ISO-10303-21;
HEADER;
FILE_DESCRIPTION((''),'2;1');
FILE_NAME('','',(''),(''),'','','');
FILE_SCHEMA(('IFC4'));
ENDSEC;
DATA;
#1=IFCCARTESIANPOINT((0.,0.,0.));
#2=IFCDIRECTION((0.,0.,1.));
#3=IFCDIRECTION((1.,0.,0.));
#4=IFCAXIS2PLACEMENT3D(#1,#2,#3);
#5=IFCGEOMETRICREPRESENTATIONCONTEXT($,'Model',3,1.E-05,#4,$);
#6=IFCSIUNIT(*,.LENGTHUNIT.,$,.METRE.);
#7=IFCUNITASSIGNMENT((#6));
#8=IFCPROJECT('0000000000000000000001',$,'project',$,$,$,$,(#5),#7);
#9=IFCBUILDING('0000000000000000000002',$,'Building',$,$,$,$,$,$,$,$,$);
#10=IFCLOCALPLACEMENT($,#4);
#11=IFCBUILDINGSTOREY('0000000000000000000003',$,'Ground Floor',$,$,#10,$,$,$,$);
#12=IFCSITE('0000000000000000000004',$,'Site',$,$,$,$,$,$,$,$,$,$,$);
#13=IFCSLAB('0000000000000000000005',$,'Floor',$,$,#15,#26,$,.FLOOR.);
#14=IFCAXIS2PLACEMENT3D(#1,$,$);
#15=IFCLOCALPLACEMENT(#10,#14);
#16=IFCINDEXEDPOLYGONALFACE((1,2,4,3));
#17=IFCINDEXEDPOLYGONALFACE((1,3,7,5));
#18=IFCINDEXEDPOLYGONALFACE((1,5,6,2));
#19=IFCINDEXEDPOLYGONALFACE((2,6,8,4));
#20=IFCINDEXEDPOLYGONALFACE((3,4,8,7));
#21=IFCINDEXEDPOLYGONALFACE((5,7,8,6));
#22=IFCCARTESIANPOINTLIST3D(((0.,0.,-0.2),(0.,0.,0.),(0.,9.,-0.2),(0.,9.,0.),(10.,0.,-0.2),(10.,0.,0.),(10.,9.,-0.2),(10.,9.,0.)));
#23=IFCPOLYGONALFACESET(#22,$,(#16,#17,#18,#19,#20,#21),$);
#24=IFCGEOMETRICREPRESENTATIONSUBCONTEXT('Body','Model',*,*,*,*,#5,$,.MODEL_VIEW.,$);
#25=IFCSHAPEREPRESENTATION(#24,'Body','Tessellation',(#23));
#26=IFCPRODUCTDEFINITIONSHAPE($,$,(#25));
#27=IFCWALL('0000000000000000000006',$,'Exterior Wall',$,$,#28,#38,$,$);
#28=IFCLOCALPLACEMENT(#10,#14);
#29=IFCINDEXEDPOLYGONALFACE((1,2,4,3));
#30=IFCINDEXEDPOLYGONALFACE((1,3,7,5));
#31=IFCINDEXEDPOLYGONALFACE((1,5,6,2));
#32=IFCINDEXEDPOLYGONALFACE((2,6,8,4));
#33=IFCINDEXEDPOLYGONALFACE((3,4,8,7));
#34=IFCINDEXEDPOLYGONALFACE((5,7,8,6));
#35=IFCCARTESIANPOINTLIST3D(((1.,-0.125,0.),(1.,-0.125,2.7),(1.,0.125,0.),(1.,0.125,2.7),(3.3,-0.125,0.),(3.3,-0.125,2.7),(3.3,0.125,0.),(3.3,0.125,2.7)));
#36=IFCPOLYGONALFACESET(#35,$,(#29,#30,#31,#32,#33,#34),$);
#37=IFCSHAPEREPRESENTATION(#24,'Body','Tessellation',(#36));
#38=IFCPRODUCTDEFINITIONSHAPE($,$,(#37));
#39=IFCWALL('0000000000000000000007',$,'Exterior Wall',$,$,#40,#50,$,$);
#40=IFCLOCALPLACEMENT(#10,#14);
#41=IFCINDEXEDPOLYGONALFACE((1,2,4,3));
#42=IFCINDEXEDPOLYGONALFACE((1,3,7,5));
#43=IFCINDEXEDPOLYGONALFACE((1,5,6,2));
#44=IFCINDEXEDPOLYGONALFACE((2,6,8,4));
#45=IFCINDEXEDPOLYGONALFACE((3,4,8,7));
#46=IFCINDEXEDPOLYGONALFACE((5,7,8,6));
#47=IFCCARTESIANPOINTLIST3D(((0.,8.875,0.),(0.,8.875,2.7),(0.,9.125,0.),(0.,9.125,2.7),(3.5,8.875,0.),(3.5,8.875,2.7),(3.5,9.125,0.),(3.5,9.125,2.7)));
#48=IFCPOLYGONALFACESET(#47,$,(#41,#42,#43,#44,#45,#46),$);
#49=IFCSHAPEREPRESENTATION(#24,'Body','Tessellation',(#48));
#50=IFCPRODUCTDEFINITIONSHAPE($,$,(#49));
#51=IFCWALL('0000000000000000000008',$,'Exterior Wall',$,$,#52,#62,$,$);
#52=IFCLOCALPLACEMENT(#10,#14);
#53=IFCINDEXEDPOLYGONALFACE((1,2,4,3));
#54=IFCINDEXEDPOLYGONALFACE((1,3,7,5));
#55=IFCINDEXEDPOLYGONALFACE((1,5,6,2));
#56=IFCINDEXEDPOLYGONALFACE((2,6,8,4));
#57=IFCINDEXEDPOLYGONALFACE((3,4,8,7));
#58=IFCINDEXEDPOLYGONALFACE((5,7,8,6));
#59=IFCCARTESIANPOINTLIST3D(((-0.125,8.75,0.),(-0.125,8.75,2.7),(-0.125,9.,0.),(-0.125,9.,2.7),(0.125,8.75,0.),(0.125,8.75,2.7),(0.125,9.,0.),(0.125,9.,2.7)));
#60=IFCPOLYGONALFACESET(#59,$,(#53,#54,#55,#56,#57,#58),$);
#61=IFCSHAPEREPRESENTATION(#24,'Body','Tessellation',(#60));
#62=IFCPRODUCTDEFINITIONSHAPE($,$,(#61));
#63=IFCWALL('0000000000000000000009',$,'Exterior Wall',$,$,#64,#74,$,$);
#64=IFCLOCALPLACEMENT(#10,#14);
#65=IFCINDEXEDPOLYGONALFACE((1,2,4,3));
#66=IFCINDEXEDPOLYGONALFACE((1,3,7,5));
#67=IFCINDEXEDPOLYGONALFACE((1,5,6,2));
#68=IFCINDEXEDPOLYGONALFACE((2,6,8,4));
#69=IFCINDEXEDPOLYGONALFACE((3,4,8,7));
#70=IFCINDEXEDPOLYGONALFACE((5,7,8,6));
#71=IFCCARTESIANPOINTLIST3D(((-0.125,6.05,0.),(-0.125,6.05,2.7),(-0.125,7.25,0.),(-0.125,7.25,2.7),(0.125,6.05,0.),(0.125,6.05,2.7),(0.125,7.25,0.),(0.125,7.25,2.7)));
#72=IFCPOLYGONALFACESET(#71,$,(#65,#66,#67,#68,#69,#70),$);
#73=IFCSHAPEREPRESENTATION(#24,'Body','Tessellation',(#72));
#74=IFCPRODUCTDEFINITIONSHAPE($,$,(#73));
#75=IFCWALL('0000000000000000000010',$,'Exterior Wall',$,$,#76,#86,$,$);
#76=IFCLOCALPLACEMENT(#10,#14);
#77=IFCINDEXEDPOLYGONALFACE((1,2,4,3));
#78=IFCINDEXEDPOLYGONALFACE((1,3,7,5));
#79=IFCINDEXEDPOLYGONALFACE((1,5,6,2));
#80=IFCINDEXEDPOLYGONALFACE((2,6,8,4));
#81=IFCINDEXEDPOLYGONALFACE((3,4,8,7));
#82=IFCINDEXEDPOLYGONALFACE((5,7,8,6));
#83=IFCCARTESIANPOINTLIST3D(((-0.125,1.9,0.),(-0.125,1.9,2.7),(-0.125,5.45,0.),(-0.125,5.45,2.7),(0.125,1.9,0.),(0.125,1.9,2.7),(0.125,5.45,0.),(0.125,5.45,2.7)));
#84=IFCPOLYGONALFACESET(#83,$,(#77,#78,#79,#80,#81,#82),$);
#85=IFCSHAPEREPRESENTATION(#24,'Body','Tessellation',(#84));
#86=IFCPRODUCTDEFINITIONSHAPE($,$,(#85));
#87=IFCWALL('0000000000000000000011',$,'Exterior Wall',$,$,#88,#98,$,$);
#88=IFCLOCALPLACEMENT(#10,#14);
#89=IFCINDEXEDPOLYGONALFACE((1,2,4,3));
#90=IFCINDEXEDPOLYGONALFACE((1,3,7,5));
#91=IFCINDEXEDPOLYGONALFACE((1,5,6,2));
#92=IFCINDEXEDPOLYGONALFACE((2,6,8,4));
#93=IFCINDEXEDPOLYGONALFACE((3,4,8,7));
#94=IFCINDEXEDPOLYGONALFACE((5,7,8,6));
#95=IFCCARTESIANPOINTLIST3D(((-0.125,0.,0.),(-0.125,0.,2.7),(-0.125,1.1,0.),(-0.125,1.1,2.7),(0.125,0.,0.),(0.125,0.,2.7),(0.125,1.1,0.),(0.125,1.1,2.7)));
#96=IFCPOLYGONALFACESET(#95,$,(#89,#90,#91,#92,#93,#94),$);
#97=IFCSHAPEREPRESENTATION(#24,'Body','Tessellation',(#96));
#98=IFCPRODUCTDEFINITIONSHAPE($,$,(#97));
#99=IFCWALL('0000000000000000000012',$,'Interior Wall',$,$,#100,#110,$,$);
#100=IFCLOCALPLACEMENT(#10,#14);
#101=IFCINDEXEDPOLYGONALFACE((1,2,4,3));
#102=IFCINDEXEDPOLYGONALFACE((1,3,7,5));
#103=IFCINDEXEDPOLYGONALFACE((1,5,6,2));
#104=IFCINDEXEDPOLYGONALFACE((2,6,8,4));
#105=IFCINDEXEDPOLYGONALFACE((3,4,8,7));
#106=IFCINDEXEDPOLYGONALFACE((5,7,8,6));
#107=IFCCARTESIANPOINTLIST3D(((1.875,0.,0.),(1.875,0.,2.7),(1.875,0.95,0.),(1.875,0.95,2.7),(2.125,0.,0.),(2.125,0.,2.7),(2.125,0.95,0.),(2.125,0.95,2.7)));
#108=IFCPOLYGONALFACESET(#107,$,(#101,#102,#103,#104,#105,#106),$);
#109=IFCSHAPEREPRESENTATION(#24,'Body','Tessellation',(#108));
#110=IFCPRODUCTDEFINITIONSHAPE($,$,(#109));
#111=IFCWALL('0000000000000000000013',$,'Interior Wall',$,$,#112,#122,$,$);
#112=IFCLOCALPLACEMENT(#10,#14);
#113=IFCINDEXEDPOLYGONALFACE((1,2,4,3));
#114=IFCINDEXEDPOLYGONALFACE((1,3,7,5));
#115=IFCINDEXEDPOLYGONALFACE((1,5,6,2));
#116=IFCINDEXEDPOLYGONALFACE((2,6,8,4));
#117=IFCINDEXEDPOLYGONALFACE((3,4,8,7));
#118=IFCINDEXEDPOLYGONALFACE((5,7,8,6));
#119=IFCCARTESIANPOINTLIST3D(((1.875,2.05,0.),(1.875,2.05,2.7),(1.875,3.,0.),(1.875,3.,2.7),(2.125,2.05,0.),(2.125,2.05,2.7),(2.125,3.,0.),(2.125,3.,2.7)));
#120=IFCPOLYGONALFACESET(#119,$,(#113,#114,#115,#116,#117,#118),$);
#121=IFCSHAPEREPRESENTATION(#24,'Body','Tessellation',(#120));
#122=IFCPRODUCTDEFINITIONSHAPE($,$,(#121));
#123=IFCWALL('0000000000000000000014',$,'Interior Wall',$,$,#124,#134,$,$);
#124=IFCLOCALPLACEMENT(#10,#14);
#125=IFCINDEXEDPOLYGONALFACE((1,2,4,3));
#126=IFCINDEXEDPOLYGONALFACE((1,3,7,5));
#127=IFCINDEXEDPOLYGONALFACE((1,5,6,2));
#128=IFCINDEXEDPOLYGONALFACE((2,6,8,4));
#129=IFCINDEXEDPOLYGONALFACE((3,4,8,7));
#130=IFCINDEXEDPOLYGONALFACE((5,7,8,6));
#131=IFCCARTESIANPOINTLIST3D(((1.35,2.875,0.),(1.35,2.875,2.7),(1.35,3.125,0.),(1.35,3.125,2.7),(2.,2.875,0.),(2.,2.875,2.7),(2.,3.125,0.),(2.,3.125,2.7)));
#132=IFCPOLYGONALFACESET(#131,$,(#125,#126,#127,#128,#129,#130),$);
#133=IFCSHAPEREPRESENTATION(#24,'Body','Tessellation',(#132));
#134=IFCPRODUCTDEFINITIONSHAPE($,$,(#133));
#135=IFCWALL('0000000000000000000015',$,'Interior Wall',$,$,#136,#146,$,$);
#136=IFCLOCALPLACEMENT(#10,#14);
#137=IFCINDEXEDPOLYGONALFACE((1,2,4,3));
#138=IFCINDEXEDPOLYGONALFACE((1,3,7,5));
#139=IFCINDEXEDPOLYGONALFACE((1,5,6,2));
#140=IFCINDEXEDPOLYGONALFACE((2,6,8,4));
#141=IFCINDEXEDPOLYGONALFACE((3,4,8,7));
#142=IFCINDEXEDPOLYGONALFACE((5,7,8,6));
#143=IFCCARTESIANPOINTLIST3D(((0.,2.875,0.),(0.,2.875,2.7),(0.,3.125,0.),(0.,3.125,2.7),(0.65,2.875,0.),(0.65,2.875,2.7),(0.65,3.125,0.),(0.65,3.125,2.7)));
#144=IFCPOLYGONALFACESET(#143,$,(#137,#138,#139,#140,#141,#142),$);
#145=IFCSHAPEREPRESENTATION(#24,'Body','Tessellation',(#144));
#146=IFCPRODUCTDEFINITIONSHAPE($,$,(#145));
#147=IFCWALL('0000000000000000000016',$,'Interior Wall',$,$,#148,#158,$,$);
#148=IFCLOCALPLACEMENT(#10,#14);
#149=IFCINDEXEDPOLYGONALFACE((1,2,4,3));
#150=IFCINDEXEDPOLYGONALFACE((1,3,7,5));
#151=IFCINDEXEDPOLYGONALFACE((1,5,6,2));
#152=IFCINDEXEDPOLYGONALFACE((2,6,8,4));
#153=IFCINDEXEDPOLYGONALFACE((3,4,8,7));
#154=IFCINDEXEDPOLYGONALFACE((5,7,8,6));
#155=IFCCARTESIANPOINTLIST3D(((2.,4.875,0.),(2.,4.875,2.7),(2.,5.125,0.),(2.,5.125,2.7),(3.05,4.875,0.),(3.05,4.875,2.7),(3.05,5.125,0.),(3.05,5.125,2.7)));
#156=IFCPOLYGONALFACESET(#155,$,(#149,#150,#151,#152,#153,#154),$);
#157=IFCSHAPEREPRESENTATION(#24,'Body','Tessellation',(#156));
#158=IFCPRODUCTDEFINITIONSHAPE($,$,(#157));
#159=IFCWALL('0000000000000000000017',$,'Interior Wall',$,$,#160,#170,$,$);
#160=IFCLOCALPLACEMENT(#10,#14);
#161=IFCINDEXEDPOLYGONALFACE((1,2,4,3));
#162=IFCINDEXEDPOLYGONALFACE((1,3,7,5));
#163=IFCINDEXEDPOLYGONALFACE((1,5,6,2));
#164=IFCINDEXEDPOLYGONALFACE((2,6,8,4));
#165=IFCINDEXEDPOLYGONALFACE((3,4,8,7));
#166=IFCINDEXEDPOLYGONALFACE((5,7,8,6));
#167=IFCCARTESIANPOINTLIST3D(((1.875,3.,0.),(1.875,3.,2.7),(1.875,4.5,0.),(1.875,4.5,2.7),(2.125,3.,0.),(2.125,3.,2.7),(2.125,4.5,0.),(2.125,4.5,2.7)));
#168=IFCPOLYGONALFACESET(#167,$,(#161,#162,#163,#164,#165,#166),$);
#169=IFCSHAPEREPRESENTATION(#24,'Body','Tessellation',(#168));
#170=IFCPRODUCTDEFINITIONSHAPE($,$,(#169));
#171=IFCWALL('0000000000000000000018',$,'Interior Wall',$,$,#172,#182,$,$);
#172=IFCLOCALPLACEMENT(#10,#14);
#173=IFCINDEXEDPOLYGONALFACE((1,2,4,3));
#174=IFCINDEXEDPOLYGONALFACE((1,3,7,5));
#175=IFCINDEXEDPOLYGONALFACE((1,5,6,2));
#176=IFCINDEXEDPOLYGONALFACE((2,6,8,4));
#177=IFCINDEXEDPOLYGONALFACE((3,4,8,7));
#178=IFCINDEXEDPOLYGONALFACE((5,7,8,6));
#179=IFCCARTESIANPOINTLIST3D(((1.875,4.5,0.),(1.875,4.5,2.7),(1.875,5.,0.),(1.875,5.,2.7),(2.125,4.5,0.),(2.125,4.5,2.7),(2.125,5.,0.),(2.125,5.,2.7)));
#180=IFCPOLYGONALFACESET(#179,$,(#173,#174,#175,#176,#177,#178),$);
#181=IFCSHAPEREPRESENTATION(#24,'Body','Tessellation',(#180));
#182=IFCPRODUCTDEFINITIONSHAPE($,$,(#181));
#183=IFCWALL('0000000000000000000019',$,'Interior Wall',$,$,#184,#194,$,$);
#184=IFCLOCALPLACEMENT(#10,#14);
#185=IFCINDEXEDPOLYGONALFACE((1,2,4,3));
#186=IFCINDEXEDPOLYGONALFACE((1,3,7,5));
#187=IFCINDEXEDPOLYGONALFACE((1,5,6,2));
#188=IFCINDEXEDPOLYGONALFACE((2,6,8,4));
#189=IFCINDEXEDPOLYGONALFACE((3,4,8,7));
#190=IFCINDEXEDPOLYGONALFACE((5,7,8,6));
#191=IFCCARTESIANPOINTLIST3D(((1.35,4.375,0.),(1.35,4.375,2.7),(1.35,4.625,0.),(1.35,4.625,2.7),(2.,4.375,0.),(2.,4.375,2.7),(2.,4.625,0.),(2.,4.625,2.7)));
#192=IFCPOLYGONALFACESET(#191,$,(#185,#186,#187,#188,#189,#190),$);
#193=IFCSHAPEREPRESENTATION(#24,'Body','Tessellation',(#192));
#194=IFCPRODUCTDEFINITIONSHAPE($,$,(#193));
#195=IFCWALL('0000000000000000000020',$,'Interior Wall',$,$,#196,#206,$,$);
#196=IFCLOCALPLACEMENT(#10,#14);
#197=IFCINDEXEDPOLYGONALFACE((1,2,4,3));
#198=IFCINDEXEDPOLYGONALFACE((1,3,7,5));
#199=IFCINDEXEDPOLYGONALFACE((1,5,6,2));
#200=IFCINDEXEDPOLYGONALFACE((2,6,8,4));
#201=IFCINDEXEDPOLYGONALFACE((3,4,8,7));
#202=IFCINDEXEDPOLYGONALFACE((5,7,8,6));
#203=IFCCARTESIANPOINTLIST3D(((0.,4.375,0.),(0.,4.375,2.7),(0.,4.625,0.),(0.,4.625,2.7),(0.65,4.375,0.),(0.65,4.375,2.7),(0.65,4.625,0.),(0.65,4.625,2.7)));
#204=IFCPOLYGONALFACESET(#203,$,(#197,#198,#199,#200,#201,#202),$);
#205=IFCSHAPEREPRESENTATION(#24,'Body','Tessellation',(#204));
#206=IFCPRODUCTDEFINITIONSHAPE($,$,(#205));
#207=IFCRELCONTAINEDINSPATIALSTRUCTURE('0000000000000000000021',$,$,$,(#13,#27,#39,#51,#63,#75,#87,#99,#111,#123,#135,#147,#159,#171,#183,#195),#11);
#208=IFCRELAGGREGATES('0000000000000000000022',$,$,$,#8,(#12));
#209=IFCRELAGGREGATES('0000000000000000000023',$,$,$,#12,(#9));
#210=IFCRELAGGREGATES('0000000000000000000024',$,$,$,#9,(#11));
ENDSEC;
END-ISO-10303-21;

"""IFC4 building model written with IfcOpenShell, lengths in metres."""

from ifc_helpers import new_model, si_unit, frame, origin_with_axes, place, context, subcontext, project, spatial, indexed_curve, outline, extrude, element, save


model = new_model("IFC4")

# Units and contexts
model_context = context("Model", 3, precision=1e-05, world=origin_with_axes())
body_context = subcontext(model_context, "Body", "Model", "MODEL_VIEW")
ifc_project = project(units=[si_unit("LENGTHUNIT", "METRE")], contexts=[model_context])

# Site, building, storey
site = spatial("IfcSite", under=ifc_project, Name="Site")
building = spatial("IfcBuilding", under=site, Name="Building")
storey_placement = place(None, origin_with_axes())
storey = spatial("IfcBuildingStorey", under=building, at=storey_placement, Name="Ground Floor")

# Slab
slab_placement = place(storey_placement, frame((0.0, 0.0, -0.2), z_axis=(0.0, 0.0, 1.0), x_axis=(1.0, 0.0, 0.0)))
element("IfcSlab", 1, at=slab_placement, inside=storey, Name="Floor", PredefinedType="FLOOR", context=body_context, shape_type="SweptSolid", body=[
    extrude(outline(indexed_curve([(0.0, 0.0), (10.0, 0.0), (10.0, 9.0), (0.0, 9.0)])), None, (0.0, 0.0, 1.0), 0.2),
])

# Walls
wall_1_placement = place(storey_placement, frame((1.0, 0.0, 0.0), z_axis=(0.0, 0.0, 1.0), x_axis=(1.0, 0.0, 0.0)))
element("IfcWall", 2, at=wall_1_placement, inside=storey, Name="Exterior Wall", context=body_context, shape_type="SweptSolid", body=[
    extrude(outline(indexed_curve([(0.0, 0.0), (0.0, 0.25), (2.3, 0.25), (2.3, 0.0), (0.0, 0.0)], self_intersect=False)), frame((0.0, -0.125, 0.0), z_axis=(0.0, 0.0, 1.0), x_axis=(1.0, 0.0, 0.0)), (0.0, 0.0, 1.0), 2.7),
])
wall_2_placement = place(storey_placement, frame((3.5, 9.0, 0.0), z_axis=(0.0, 0.0, 1.0), x_axis=(-1.0, 0.0, 0.0)))
element("IfcWall", 3, at=wall_2_placement, inside=storey, Name="Exterior Wall", context=body_context, shape_type="SweptSolid", body=[
    extrude(outline(indexed_curve([(0.0, 0.0), (0.0, 0.25), (3.5, 0.25), (3.5, 0.0), (0.0, 0.0)], self_intersect=False)), frame((0.0, -0.125, 0.0), z_axis=(0.0, 0.0, 1.0), x_axis=(1.0, 0.0, 0.0)), (0.0, 0.0, 1.0), 2.7),
])
wall_3_placement = place(storey_placement, frame((0.0, 9.0, 0.0), z_axis=(0.0, 0.0, 1.0), x_axis=(0.0, -1.0, 0.0)))
element("IfcWall", 4, at=wall_3_placement, inside=storey, Name="Exterior Wall", context=body_context, shape_type="SweptSolid", body=[
    extrude(outline(indexed_curve([(0.0, 0.0), (0.0, 0.25), (0.25, 0.25), (0.25, 0.0), (0.0, 0.0)], self_intersect=False)), frame((0.0, -0.125, 0.0), z_axis=(0.0, 0.0, 1.0), x_axis=(1.0, 0.0, 0.0)), (0.0, 0.0, 1.0), 2.7),
])
wall_4_placement = place(storey_placement, frame((0.0, 7.25, 0.0), z_axis=(0.0, 0.0, 1.0), x_axis=(0.0, -1.0, 0.0)))
element("IfcWall", 5, at=wall_4_placement, inside=storey, Name="Exterior Wall", context=body_context, shape_type="SweptSolid", body=[
    extrude(outline(indexed_curve([(0.0, 0.0), (0.0, 0.25), (1.2, 0.25), (1.2, 0.0), (0.0, 0.0)], self_intersect=False)), frame((0.0, -0.125, 0.0), z_axis=(0.0, 0.0, 1.0), x_axis=(1.0, 0.0, 0.0)), (0.0, 0.0, 1.0), 2.7),
])
wall_5_placement = place(storey_placement, frame((0.0, 5.45, 0.0), z_axis=(0.0, 0.0, 1.0), x_axis=(0.0, -1.0, 0.0)))
element("IfcWall", 6, at=wall_5_placement, inside=storey, Name="Exterior Wall", context=body_context, shape_type="SweptSolid", body=[
    extrude(outline(indexed_curve([(0.0, 0.0), (0.0, 0.25), (3.55, 0.25), (3.55, 0.0), (0.0, 0.0)], self_intersect=False)), frame((0.0, -0.125, 0.0), z_axis=(0.0, 0.0, 1.0), x_axis=(1.0, 0.0, 0.0)), (0.0, 0.0, 1.0), 2.7),
])
wall_6_placement = place(storey_placement, frame((0.0, 1.1, 0.0), z_axis=(0.0, 0.0, 1.0), x_axis=(0.0, -1.0, 0.0)))
element("IfcWall", 7, at=wall_6_placement, inside=storey, Name="Exterior Wall", context=body_context, shape_type="SweptSolid", body=[
    extrude(outline(indexed_curve([(0.0, 0.0), (0.0, 0.25), (1.1, 0.25), (1.1, 0.0), (0.0, 0.0)], self_intersect=False)), frame((0.0, -0.125, 0.0), z_axis=(0.0, 0.0, 1.0), x_axis=(1.0, 0.0, 0.0)), (0.0, 0.0, 1.0), 2.7),
])
wall_7_placement = place(storey_placement, frame((2.0, 0.0, 0.0), z_axis=(0.0, 0.0, 1.0), x_axis=(0.0, 1.0, 0.0)))
element("IfcWall", 8, at=wall_7_placement, inside=storey, Name="Interior Wall", context=body_context, shape_type="SweptSolid", body=[
    extrude(outline(indexed_curve([(0.0, 0.0), (0.0, 0.25), (0.95, 0.25), (0.95, 0.0), (0.0, 0.0)], self_intersect=False)), frame((0.0, -0.125, 0.0), z_axis=(0.0, 0.0, 1.0), x_axis=(1.0, 0.0, 0.0)), (0.0, 0.0, 1.0), 2.7),
])
wall_8_placement = place(storey_placement, frame((2.0, 2.05, 0.0), z_axis=(0.0, 0.0, 1.0), x_axis=(0.0, 1.0, 0.0)))
element("IfcWall", 9, at=wall_8_placement, inside=storey, Name="Interior Wall", context=body_context, shape_type="SweptSolid", body=[
    extrude(outline(indexed_curve([(0.0, 0.0), (0.0, 0.25), (0.95, 0.25), (0.95, 0.0), (0.0, 0.0)], self_intersect=False)), frame((0.0, -0.125, 0.0), z_axis=(0.0, 0.0, 1.0), x_axis=(1.0, 0.0, 0.0)), (0.0, 0.0, 1.0), 2.7),
])
for number, where, z_axis, x_axis, name in (
    (10, (2.0, 3.0, 0.0), (0.0, 0.0, 1.0), (-1.0, 0.0, 0.0), "Interior Wall"),
    (11, (0.65, 3.0, 0.0), (0.0, 0.0, 1.0), (-1.0, 0.0, 0.0), "Interior Wall"),
):
    element("IfcWall", number, at=place(storey_placement, frame(where, z_axis=z_axis, x_axis=x_axis)), inside=storey, Name=name, context=body_context, shape_type="SweptSolid", body=[
        extrude(outline(indexed_curve([(0.0, 0.0), (0.0, 0.25), (0.65, 0.25), (0.65, 0.0), (0.0, 0.0)], self_intersect=False)), frame((0.0, -0.125, 0.0), z_axis=(0.0, 0.0, 1.0), x_axis=(1.0, 0.0, 0.0)), (0.0, 0.0, 1.0), 2.7),
    ])
wall_9_placement = place(storey_placement, frame((3.05, 5.0, 0.0), z_axis=(0.0, 0.0, 1.0), x_axis=(-1.0, 0.0, 0.0)))
element("IfcWall", 12, at=wall_9_placement, inside=storey, Name="Interior Wall", context=body_context, shape_type="SweptSolid", body=[
    extrude(outline(indexed_curve([(0.0, 0.0), (0.0, 0.25), (1.05, 0.25), (1.05, 0.0), (0.0, 0.0)], self_intersect=False)), frame((0.0, -0.125, 0.0), z_axis=(0.0, 0.0, 1.0), x_axis=(1.0, 0.0, 0.0)), (0.0, 0.0, 1.0), 2.7),
])
wall_10_placement = place(storey_placement, frame((2.0, 4.5, 0.0), z_axis=(0.0, 0.0, 1.0), x_axis=(0.0, -1.0, 0.0)))
element("IfcWall", 13, at=wall_10_placement, inside=storey, Name="Interior Wall", context=body_context, shape_type="SweptSolid", body=[
    extrude(outline(indexed_curve([(0.0, 0.0), (0.0, 0.25), (1.5, 0.25), (1.5, 0.0), (0.0, 0.0)], self_intersect=False)), frame((0.0, -0.125, 0.0), z_axis=(0.0, 0.0, 1.0), x_axis=(1.0, 0.0, 0.0)), (0.0, 0.0, 1.0), 2.7),
])
wall_11_placement = place(storey_placement, frame((2.0, 5.0, 0.0), z_axis=(0.0, 0.0, 1.0), x_axis=(0.0, -1.0, 0.0)))
element("IfcWall", 14, at=wall_11_placement, inside=storey, Name="Interior Wall", context=body_context, shape_type="SweptSolid", body=[
    extrude(outline(indexed_curve([(0.0, 0.0), (0.0, 0.25), (0.5, 0.25), (0.5, 0.0), (0.0, 0.0)], self_intersect=False)), frame((0.0, -0.125, 0.0), z_axis=(0.0, 0.0, 1.0), x_axis=(1.0, 0.0, 0.0)), (0.0, 0.0, 1.0), 2.7),
])
for number, where, z_axis, x_axis, name in (
    (15, (2.0, 4.5, 0.0), (0.0, 0.0, 1.0), (-1.0, 0.0, 0.0), "Interior Wall"),
    (16, (0.65, 4.5, 0.0), (0.0, 0.0, 1.0), (-1.0, 0.0, 0.0), "Interior Wall"),
):
    element("IfcWall", number, at=place(storey_placement, frame(where, z_axis=z_axis, x_axis=x_axis)), inside=storey, Name=name, context=body_context, shape_type="SweptSolid", body=[
        extrude(outline(indexed_curve([(0.0, 0.0), (0.0, 0.25), (0.65, 0.25), (0.65, 0.0), (0.0, 0.0)], self_intersect=False)), frame((0.0, -0.125, 0.0), z_axis=(0.0, 0.0, 1.0), x_axis=(1.0, 0.0, 0.0)), (0.0, 0.0, 1.0), 2.7),
    ])

save(model, "model.ifc")
